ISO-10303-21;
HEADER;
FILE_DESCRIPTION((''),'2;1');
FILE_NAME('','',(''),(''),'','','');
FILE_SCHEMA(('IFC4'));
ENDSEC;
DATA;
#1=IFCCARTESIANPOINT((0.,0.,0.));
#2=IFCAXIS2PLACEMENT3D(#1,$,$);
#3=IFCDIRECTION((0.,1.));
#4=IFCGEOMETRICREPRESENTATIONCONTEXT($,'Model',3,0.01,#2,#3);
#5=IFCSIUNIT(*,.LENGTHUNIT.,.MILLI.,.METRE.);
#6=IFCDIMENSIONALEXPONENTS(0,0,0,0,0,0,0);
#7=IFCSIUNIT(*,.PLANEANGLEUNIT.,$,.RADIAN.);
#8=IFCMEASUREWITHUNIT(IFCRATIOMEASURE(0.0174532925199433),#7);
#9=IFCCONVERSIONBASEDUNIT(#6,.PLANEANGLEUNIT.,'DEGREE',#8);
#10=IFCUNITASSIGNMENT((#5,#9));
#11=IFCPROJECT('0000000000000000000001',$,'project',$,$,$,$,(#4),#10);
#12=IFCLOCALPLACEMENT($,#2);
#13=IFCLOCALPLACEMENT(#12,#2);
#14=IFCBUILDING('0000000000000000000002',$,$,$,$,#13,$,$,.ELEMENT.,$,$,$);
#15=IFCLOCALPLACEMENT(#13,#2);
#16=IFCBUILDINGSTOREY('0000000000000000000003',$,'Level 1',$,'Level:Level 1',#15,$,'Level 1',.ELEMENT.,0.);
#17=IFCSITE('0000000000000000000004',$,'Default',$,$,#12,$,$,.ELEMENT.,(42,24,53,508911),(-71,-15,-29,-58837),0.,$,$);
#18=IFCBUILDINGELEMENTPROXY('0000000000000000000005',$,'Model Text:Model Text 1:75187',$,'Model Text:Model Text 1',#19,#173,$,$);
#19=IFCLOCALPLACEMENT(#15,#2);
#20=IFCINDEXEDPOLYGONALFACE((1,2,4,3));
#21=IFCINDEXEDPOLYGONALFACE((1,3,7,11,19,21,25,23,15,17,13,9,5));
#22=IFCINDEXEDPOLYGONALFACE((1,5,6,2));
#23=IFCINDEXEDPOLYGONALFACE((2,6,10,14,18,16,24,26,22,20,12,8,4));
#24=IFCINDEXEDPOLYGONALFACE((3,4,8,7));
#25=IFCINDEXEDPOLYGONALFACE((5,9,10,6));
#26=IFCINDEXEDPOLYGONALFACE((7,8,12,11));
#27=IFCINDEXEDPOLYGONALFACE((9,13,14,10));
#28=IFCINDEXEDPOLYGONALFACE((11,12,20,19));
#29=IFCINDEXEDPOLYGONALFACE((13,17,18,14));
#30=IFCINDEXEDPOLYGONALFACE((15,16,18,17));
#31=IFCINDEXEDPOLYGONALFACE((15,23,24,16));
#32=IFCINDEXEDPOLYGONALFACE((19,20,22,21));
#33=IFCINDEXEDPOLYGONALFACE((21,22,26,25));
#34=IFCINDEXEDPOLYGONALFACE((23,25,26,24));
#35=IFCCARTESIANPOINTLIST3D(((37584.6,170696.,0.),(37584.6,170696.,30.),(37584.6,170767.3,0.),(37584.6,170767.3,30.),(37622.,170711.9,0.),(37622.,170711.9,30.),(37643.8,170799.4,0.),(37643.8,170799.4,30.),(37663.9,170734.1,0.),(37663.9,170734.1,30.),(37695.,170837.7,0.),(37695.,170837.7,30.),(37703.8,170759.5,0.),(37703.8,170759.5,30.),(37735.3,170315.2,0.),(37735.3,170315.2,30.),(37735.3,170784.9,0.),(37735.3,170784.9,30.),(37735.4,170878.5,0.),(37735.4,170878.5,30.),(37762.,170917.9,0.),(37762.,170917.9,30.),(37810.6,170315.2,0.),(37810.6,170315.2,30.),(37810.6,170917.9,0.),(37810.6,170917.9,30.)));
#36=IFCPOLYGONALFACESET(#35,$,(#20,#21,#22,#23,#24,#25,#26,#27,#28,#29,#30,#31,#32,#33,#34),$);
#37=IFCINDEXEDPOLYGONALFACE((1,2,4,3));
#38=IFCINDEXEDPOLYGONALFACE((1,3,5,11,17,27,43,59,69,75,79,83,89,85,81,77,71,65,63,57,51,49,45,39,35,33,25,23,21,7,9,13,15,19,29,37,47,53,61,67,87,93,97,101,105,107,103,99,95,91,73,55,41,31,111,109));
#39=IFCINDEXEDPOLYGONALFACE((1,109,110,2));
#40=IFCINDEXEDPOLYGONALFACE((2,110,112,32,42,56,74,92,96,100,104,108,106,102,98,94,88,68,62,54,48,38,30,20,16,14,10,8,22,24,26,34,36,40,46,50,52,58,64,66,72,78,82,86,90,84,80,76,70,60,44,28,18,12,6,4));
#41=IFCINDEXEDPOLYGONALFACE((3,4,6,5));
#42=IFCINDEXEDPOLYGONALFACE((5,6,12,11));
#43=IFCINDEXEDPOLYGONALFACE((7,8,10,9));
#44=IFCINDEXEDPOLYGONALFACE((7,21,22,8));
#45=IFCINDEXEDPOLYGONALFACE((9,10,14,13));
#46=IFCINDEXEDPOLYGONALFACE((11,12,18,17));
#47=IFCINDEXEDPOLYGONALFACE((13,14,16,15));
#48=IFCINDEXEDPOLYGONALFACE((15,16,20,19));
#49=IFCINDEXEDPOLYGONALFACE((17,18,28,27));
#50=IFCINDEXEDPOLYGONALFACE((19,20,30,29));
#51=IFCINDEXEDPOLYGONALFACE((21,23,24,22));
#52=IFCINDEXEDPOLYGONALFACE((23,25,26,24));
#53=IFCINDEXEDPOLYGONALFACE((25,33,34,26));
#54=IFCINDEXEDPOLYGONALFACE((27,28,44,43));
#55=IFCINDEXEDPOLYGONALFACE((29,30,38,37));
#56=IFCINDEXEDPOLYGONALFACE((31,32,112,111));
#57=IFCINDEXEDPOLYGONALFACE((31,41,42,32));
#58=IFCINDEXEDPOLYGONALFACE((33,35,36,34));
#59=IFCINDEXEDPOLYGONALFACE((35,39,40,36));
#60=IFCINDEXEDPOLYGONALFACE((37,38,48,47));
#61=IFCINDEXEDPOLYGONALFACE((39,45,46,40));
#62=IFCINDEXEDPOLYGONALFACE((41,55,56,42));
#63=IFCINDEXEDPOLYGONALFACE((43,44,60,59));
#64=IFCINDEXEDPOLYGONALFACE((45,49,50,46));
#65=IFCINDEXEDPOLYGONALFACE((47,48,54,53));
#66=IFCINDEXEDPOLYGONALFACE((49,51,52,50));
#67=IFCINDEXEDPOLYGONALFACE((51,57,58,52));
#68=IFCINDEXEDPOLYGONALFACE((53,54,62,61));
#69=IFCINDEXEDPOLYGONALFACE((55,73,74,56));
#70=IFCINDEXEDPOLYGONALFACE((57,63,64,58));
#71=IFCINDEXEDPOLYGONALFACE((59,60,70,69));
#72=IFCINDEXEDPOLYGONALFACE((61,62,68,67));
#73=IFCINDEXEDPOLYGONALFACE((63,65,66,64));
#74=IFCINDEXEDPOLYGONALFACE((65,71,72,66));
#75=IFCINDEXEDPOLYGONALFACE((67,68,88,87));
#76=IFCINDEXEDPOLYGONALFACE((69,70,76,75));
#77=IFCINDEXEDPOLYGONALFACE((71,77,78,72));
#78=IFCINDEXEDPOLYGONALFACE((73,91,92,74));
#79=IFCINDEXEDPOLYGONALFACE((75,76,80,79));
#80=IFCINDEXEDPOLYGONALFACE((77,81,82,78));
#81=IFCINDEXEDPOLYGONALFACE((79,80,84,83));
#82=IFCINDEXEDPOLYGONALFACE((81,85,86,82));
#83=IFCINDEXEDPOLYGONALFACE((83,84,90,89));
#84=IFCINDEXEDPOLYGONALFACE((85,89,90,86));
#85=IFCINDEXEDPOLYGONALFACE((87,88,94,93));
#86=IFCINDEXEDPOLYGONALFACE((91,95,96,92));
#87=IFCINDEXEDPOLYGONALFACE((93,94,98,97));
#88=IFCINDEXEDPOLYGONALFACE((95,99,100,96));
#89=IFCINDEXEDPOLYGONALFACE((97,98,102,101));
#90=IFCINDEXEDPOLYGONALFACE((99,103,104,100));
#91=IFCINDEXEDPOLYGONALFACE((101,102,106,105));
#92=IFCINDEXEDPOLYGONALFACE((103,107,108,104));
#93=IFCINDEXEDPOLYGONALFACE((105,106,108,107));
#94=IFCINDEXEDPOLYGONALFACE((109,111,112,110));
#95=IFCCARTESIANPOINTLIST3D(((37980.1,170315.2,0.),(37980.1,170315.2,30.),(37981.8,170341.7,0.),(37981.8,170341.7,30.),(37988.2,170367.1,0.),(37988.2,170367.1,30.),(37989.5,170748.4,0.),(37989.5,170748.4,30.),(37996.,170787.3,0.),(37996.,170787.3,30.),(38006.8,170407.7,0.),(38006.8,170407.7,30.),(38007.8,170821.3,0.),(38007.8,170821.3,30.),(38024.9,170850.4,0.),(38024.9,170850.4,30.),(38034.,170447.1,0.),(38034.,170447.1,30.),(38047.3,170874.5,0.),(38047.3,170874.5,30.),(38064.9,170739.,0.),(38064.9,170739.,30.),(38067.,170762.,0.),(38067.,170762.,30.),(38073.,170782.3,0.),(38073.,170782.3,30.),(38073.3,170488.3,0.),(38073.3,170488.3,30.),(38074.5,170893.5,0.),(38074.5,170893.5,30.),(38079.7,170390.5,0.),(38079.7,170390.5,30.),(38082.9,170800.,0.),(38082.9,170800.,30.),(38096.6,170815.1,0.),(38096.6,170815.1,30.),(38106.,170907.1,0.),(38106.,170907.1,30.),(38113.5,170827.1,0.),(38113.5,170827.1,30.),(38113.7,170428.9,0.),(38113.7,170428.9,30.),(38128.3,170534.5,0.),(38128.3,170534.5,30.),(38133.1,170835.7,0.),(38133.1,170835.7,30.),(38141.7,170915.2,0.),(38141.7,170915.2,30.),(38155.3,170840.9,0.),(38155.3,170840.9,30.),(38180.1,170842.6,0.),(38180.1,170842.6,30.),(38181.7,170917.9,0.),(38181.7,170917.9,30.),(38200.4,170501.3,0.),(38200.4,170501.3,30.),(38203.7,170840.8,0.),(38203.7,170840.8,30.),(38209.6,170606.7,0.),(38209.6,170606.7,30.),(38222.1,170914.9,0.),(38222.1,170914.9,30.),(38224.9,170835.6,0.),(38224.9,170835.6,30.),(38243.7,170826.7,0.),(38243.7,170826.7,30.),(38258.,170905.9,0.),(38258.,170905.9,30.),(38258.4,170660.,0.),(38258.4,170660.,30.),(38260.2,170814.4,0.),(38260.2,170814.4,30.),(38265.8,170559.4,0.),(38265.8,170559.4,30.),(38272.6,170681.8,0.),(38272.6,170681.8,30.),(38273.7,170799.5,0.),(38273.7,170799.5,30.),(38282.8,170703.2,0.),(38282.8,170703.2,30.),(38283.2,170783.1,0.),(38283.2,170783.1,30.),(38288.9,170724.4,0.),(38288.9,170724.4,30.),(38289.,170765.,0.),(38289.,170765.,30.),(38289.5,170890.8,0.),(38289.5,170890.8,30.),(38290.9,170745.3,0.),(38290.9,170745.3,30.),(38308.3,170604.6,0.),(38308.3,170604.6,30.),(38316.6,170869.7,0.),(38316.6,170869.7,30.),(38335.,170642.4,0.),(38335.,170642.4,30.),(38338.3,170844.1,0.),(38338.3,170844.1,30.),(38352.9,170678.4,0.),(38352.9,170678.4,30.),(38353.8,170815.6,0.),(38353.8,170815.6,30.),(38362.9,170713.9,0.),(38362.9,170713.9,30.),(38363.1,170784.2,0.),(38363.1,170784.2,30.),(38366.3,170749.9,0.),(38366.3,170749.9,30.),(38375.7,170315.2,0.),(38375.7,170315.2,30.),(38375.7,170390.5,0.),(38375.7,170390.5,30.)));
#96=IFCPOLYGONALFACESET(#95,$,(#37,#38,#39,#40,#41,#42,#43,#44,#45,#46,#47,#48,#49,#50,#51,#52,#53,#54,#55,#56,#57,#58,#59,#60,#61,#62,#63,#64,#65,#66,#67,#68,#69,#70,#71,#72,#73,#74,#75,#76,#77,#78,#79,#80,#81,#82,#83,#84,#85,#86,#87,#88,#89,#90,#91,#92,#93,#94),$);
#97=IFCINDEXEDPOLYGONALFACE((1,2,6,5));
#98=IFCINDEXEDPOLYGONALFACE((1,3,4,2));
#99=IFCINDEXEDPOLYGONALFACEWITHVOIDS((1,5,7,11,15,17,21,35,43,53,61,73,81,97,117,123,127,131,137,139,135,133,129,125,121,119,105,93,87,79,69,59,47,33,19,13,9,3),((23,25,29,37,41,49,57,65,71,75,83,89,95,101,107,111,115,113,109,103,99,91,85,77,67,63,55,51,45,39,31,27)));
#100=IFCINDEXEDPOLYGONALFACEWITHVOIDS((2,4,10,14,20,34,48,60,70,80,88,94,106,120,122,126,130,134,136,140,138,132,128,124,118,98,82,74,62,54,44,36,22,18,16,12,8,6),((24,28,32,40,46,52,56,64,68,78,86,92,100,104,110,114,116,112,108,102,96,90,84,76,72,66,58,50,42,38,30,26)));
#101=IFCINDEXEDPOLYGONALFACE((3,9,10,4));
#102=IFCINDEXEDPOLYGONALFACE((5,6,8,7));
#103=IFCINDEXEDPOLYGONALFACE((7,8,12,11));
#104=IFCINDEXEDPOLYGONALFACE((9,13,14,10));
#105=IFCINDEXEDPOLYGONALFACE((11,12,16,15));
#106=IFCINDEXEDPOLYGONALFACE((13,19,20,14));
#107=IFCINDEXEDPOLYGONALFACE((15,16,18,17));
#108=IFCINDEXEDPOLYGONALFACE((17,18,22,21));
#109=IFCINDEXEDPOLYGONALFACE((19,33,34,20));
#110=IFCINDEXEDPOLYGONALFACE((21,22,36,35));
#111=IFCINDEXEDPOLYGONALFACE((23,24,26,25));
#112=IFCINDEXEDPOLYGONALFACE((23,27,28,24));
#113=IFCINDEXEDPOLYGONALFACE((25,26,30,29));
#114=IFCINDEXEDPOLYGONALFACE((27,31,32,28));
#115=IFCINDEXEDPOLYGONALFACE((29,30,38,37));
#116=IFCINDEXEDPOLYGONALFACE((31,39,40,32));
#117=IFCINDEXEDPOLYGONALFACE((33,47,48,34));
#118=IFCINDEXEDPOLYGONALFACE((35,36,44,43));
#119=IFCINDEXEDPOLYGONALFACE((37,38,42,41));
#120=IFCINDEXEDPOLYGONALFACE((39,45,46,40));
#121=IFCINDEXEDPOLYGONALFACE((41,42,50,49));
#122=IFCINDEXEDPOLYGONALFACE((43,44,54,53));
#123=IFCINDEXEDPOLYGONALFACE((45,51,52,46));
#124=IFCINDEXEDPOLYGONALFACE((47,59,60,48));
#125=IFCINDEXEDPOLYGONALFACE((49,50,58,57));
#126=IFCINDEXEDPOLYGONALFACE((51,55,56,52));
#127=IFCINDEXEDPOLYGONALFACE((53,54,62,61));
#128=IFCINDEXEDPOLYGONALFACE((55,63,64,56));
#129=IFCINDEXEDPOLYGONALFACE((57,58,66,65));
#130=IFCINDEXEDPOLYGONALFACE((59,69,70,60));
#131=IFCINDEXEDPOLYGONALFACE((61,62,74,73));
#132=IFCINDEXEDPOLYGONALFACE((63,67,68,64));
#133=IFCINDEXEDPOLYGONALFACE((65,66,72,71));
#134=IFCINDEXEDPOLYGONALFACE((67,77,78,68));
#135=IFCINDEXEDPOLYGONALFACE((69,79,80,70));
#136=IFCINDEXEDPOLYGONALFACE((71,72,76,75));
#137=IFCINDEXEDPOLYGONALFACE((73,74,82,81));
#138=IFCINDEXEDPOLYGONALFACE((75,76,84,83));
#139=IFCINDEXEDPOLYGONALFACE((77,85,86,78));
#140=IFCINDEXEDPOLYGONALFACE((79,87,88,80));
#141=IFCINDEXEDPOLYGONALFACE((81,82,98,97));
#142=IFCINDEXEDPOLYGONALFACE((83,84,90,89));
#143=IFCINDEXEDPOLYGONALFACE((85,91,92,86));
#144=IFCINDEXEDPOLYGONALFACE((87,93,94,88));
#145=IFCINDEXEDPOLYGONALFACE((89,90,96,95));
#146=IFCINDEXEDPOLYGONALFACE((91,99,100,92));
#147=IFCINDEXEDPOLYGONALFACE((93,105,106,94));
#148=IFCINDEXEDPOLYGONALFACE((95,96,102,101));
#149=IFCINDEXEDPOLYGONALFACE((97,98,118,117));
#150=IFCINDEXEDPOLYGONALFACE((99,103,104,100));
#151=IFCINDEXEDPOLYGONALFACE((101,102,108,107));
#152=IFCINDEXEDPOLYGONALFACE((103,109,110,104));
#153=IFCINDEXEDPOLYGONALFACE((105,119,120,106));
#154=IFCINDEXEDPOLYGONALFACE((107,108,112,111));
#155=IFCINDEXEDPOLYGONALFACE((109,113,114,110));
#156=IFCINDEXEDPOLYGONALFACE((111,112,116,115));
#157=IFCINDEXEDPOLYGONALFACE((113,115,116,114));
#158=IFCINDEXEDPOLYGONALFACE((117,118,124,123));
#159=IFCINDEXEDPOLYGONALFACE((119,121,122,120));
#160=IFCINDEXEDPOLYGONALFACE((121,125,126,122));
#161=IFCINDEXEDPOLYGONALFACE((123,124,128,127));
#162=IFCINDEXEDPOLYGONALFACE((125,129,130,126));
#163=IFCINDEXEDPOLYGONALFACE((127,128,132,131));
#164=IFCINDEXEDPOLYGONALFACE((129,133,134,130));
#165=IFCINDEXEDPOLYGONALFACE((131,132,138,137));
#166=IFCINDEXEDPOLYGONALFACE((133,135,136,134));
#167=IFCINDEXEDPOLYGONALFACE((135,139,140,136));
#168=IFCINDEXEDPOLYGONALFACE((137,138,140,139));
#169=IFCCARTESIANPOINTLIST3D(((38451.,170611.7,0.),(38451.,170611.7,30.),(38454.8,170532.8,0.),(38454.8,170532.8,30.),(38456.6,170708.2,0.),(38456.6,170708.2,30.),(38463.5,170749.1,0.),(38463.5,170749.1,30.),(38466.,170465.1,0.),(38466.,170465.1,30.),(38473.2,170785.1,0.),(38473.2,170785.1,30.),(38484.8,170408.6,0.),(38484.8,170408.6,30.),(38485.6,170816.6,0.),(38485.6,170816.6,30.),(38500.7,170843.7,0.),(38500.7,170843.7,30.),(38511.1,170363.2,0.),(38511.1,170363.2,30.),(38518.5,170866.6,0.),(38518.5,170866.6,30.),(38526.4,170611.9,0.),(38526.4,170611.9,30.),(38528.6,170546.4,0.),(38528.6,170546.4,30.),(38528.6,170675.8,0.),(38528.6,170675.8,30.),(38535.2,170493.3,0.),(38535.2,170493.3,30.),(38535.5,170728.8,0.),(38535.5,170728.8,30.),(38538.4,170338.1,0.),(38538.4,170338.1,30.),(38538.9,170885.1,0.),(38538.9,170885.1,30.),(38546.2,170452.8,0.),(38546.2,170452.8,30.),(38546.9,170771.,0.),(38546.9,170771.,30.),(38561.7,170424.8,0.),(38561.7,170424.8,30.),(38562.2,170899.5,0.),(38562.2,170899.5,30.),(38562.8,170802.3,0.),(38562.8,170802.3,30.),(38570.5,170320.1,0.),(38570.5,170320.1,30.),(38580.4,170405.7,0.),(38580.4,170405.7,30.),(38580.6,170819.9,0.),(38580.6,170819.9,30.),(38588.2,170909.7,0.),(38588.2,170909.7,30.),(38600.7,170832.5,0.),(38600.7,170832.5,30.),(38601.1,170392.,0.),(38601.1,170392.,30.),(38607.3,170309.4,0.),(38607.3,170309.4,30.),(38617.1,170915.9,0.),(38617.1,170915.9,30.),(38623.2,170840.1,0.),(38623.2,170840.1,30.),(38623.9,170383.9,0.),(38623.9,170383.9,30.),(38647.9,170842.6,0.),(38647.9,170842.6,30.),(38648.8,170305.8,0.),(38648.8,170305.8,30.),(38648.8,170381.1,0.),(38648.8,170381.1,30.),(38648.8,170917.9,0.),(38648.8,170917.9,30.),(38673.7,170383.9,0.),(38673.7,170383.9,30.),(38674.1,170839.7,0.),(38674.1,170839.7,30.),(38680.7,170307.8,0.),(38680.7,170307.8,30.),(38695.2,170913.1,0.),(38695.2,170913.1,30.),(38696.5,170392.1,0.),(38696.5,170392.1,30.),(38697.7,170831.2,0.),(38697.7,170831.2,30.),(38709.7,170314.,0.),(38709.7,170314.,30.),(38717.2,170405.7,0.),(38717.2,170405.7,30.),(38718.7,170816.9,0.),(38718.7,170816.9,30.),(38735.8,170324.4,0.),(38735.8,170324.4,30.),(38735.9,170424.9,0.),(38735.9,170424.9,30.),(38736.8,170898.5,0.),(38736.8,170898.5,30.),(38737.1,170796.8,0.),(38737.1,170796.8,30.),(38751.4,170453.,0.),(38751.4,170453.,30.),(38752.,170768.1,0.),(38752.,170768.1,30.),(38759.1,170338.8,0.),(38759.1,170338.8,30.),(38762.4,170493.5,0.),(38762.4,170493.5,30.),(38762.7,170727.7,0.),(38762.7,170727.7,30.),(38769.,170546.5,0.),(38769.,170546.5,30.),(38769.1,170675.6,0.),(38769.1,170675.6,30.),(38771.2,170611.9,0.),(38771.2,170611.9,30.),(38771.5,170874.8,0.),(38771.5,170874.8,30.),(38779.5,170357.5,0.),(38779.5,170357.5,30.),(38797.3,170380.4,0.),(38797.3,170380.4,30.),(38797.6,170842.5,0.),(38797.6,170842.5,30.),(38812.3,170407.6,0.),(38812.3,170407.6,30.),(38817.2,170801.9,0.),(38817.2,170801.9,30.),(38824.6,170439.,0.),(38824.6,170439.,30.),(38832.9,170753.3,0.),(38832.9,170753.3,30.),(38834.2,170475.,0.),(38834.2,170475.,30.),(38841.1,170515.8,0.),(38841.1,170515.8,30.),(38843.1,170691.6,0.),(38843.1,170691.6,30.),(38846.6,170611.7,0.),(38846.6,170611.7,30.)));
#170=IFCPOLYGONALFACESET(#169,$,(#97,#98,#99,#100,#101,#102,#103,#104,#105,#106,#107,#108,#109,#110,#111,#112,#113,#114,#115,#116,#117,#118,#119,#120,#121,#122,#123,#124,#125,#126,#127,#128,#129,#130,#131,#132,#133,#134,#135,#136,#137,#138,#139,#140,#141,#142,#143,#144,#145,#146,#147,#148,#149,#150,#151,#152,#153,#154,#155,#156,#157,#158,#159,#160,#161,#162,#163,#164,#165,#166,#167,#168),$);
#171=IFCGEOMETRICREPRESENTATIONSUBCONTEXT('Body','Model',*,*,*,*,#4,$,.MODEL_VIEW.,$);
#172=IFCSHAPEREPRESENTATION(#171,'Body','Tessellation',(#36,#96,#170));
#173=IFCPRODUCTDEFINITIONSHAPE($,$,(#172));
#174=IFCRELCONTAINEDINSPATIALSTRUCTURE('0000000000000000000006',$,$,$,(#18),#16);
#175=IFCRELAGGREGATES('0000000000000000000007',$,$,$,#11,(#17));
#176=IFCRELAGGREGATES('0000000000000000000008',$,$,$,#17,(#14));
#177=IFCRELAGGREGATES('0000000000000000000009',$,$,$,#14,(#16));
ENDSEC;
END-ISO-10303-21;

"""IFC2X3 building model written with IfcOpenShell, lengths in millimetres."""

from ifc_helpers import new_model, entity, si_unit, converted_unit, direction, frame, origin, place, context, subcontext, project, spatial, polyline, outline, extrude, element, save


model = new_model("IFC2X3")

# Units and contexts
model_context = context("Model", 3, precision=0.01, world=origin(), true_north=direction((0.0, 1.0)))
body_context = subcontext(model_context, "Body", "Model", "MODEL_VIEW")
ifc_project = project(units=[si_unit("LENGTHUNIT", "METRE", prefix="MILLI"), converted_unit("PLANEANGLEUNIT", "DEGREE", entity("IfcRatioMeasure", 0.0174532925199433), si_unit("PLANEANGLEUNIT", "RADIAN"), dimensions=[0, 0, 0, 0, 0, 0, 0])], contexts=[model_context])

# Site, building, storey
site_placement = place(None, origin())
site = spatial("IfcSite", under=ifc_project, at=site_placement, Name="Default", CompositionType="ELEMENT", RefLatitude=(42, 24, 53, 508911), RefLongitude=(-71, -15, -29, -58837), RefElevation=0.0)
building_placement = place(site_placement, origin())
building = spatial("IfcBuilding", under=site, at=building_placement, CompositionType="ELEMENT")
storey_placement = place(building_placement, origin())
storey = spatial("IfcBuildingStorey", under=building, at=storey_placement, Name="Level 1", ObjectType="Level:Level 1", LongName="Level 1", CompositionType="ELEMENT", Elevation=0.0)

# Building element proxy
proxy_1_placement = place(storey_placement, origin())
element("IfcBuildingElementProxy", 1, at=proxy_1_placement, inside=storey, Name="Model Text:Model Text 1:75187", ObjectType="Model Text:Model Text 1", context=body_context, shape_type="SweptSolid", body=[
    extrude(outline(polyline([(-410.6, -111.6), (192.1, -111.6), (192.1, -63.1), (152.7, -36.4), (111.9, 4.0), (73.6, 55.2), (41.4, 114.4), (-29.8, 114.4), (-13.9, 77.0), (8.3, 35.1), (33.7, -4.8), (59.1, -36.3), (-410.6, -36.3), (-410.6, -111.6)])), frame((37699.0, 170725.8, 0.0), z_axis=(0.0, 0.0, 1.0), x_axis=(0.0, 1.0, 0.0)), (0.0, 0.0, 1.0), 30.0),
    extrude(outline(polyline([(-190.2, -317.5), (-190.2, -392.8), (205.4, -392.8), (203.7, -366.3), (197.3, -340.9), (178.7, -300.3), (151.5, -260.9), (112.2, -219.7), (57.2, -173.6), (-24.1, -101.3), (-72.9, -48.0), (-87.1, -26.3), (-97.3, -4.8), (-103.4, 16.4), (-105.4, 37.3), (-103.5, 57.0), (-97.7, 75.0), (-88.2, 91.5), (-74.7, 106.4), (-58.2, 118.7), (-39.4, 127.5), (-18.2, 132.8), (5.4, 134.6), (30.2, 132.9), (52.4, 127.7), (72.0, 119.1), (88.9, 107.1), (102.6, 92.0), (112.5, 74.3), (118.5, 54.0), (120.6, 31.0), (196.0, 40.4), (189.5, 79.3), (177.7, 113.3), (160.6, 142.4), (138.2, 166.5), (111.0, 185.5), (79.5, 199.1), (43.8, 207.2), (3.8, 209.9), (-36.6, 206.9), (-72.5, 197.9), (-104.0, 182.8), (-131.1, 161.7), (-152.8, 136.1), (-168.3, 107.6), (-177.6, 76.2), (-180.8, 41.9), (-177.4, 5.8), (-167.4, -29.6), (-149.5, -65.6), (-122.8, -103.4), (-80.3, -148.6), (-14.9, -206.7), (71.8, -279.1), (105.8, -317.5), (-190.2, -317.5)])), frame((38185.5, 170708.0, 0.0), z_axis=(0.0, 0.0, -1.0), x_axis=(-1.0, 0.0, 0.0)), (0.0, 0.0, -1.0), 30.0),
    extrude(outline(polyline([(-10.6, -198.7), (68.3, -198.7), (136.5, -190.7), (193.9, -174.7), (240.5, -150.6), (266.9, -124.4), (286.3, -93.2), (298.8, -57.0), (304.3, -15.7), (303.8, 16.2), (299.0, 45.5), (289.9, 72.1), (276.6, 96.0), (258.9, 117.3), (236.9, 136.2), (210.4, 152.5), (179.6, 166.3), (144.1, 177.6), (103.7, 186.3), (8.2, 196.4), (-71.8, 196.7), (-134.0, 189.4), (-183.3, 176.1), (-224.7, 158.4), (-258.2, 133.9), (-283.5, 100.3), (-300.1, 59.5), (-307.1, 13.4), (-306.6, -18.4), (-301.8, -47.5), (-292.8, -74.0), (-279.6, -97.9), (-262.0, -119.2), (-240.0, -138.1), (-213.6, -154.5), (-182.8, -168.4), (-147.3, -179.8), (-106.7, -188.6), (-10.6, -198.7)]), holes=[polyline([(-7.2, -123.5), (-71.0, -118.2), (-123.6, -108.8), (-165.2, -95.4), (-195.7, -78.0), (-212.4, -59.4), (-224.1, -38.7), (-230.6, -15.9), (-231.9, 8.9), (-227.8, 35.0), (-218.1, 58.1), (-202.8, 78.4), (-182.0, 95.8), (-152.6, 109.4), (-111.7, 118.1), (-59.4, 122.0), (4.4, 121.1), (69.6, 115.8), (122.2, 106.7), (162.2, 93.7), (189.5, 77.0), (207.7, 57.4), (220.4, 36.0), (227.5, 12.8), (229.1, -12.1), (225.2, -36.8), (215.9, -59.2), (201.3, -79.3), (181.4, -97.1), (152.6, -111.2), (111.6, -120.3), (58.3, -124.4), (-7.2, -123.5)])]), frame((38650.0, 170610.5, 0.0), z_axis=(0.0, 0.0, 1.0), x_axis=(0.047515, -0.998871, 0.0)), (0.0, 0.0, 1.0), 30.0),
])

save(model, "model.ifc")
